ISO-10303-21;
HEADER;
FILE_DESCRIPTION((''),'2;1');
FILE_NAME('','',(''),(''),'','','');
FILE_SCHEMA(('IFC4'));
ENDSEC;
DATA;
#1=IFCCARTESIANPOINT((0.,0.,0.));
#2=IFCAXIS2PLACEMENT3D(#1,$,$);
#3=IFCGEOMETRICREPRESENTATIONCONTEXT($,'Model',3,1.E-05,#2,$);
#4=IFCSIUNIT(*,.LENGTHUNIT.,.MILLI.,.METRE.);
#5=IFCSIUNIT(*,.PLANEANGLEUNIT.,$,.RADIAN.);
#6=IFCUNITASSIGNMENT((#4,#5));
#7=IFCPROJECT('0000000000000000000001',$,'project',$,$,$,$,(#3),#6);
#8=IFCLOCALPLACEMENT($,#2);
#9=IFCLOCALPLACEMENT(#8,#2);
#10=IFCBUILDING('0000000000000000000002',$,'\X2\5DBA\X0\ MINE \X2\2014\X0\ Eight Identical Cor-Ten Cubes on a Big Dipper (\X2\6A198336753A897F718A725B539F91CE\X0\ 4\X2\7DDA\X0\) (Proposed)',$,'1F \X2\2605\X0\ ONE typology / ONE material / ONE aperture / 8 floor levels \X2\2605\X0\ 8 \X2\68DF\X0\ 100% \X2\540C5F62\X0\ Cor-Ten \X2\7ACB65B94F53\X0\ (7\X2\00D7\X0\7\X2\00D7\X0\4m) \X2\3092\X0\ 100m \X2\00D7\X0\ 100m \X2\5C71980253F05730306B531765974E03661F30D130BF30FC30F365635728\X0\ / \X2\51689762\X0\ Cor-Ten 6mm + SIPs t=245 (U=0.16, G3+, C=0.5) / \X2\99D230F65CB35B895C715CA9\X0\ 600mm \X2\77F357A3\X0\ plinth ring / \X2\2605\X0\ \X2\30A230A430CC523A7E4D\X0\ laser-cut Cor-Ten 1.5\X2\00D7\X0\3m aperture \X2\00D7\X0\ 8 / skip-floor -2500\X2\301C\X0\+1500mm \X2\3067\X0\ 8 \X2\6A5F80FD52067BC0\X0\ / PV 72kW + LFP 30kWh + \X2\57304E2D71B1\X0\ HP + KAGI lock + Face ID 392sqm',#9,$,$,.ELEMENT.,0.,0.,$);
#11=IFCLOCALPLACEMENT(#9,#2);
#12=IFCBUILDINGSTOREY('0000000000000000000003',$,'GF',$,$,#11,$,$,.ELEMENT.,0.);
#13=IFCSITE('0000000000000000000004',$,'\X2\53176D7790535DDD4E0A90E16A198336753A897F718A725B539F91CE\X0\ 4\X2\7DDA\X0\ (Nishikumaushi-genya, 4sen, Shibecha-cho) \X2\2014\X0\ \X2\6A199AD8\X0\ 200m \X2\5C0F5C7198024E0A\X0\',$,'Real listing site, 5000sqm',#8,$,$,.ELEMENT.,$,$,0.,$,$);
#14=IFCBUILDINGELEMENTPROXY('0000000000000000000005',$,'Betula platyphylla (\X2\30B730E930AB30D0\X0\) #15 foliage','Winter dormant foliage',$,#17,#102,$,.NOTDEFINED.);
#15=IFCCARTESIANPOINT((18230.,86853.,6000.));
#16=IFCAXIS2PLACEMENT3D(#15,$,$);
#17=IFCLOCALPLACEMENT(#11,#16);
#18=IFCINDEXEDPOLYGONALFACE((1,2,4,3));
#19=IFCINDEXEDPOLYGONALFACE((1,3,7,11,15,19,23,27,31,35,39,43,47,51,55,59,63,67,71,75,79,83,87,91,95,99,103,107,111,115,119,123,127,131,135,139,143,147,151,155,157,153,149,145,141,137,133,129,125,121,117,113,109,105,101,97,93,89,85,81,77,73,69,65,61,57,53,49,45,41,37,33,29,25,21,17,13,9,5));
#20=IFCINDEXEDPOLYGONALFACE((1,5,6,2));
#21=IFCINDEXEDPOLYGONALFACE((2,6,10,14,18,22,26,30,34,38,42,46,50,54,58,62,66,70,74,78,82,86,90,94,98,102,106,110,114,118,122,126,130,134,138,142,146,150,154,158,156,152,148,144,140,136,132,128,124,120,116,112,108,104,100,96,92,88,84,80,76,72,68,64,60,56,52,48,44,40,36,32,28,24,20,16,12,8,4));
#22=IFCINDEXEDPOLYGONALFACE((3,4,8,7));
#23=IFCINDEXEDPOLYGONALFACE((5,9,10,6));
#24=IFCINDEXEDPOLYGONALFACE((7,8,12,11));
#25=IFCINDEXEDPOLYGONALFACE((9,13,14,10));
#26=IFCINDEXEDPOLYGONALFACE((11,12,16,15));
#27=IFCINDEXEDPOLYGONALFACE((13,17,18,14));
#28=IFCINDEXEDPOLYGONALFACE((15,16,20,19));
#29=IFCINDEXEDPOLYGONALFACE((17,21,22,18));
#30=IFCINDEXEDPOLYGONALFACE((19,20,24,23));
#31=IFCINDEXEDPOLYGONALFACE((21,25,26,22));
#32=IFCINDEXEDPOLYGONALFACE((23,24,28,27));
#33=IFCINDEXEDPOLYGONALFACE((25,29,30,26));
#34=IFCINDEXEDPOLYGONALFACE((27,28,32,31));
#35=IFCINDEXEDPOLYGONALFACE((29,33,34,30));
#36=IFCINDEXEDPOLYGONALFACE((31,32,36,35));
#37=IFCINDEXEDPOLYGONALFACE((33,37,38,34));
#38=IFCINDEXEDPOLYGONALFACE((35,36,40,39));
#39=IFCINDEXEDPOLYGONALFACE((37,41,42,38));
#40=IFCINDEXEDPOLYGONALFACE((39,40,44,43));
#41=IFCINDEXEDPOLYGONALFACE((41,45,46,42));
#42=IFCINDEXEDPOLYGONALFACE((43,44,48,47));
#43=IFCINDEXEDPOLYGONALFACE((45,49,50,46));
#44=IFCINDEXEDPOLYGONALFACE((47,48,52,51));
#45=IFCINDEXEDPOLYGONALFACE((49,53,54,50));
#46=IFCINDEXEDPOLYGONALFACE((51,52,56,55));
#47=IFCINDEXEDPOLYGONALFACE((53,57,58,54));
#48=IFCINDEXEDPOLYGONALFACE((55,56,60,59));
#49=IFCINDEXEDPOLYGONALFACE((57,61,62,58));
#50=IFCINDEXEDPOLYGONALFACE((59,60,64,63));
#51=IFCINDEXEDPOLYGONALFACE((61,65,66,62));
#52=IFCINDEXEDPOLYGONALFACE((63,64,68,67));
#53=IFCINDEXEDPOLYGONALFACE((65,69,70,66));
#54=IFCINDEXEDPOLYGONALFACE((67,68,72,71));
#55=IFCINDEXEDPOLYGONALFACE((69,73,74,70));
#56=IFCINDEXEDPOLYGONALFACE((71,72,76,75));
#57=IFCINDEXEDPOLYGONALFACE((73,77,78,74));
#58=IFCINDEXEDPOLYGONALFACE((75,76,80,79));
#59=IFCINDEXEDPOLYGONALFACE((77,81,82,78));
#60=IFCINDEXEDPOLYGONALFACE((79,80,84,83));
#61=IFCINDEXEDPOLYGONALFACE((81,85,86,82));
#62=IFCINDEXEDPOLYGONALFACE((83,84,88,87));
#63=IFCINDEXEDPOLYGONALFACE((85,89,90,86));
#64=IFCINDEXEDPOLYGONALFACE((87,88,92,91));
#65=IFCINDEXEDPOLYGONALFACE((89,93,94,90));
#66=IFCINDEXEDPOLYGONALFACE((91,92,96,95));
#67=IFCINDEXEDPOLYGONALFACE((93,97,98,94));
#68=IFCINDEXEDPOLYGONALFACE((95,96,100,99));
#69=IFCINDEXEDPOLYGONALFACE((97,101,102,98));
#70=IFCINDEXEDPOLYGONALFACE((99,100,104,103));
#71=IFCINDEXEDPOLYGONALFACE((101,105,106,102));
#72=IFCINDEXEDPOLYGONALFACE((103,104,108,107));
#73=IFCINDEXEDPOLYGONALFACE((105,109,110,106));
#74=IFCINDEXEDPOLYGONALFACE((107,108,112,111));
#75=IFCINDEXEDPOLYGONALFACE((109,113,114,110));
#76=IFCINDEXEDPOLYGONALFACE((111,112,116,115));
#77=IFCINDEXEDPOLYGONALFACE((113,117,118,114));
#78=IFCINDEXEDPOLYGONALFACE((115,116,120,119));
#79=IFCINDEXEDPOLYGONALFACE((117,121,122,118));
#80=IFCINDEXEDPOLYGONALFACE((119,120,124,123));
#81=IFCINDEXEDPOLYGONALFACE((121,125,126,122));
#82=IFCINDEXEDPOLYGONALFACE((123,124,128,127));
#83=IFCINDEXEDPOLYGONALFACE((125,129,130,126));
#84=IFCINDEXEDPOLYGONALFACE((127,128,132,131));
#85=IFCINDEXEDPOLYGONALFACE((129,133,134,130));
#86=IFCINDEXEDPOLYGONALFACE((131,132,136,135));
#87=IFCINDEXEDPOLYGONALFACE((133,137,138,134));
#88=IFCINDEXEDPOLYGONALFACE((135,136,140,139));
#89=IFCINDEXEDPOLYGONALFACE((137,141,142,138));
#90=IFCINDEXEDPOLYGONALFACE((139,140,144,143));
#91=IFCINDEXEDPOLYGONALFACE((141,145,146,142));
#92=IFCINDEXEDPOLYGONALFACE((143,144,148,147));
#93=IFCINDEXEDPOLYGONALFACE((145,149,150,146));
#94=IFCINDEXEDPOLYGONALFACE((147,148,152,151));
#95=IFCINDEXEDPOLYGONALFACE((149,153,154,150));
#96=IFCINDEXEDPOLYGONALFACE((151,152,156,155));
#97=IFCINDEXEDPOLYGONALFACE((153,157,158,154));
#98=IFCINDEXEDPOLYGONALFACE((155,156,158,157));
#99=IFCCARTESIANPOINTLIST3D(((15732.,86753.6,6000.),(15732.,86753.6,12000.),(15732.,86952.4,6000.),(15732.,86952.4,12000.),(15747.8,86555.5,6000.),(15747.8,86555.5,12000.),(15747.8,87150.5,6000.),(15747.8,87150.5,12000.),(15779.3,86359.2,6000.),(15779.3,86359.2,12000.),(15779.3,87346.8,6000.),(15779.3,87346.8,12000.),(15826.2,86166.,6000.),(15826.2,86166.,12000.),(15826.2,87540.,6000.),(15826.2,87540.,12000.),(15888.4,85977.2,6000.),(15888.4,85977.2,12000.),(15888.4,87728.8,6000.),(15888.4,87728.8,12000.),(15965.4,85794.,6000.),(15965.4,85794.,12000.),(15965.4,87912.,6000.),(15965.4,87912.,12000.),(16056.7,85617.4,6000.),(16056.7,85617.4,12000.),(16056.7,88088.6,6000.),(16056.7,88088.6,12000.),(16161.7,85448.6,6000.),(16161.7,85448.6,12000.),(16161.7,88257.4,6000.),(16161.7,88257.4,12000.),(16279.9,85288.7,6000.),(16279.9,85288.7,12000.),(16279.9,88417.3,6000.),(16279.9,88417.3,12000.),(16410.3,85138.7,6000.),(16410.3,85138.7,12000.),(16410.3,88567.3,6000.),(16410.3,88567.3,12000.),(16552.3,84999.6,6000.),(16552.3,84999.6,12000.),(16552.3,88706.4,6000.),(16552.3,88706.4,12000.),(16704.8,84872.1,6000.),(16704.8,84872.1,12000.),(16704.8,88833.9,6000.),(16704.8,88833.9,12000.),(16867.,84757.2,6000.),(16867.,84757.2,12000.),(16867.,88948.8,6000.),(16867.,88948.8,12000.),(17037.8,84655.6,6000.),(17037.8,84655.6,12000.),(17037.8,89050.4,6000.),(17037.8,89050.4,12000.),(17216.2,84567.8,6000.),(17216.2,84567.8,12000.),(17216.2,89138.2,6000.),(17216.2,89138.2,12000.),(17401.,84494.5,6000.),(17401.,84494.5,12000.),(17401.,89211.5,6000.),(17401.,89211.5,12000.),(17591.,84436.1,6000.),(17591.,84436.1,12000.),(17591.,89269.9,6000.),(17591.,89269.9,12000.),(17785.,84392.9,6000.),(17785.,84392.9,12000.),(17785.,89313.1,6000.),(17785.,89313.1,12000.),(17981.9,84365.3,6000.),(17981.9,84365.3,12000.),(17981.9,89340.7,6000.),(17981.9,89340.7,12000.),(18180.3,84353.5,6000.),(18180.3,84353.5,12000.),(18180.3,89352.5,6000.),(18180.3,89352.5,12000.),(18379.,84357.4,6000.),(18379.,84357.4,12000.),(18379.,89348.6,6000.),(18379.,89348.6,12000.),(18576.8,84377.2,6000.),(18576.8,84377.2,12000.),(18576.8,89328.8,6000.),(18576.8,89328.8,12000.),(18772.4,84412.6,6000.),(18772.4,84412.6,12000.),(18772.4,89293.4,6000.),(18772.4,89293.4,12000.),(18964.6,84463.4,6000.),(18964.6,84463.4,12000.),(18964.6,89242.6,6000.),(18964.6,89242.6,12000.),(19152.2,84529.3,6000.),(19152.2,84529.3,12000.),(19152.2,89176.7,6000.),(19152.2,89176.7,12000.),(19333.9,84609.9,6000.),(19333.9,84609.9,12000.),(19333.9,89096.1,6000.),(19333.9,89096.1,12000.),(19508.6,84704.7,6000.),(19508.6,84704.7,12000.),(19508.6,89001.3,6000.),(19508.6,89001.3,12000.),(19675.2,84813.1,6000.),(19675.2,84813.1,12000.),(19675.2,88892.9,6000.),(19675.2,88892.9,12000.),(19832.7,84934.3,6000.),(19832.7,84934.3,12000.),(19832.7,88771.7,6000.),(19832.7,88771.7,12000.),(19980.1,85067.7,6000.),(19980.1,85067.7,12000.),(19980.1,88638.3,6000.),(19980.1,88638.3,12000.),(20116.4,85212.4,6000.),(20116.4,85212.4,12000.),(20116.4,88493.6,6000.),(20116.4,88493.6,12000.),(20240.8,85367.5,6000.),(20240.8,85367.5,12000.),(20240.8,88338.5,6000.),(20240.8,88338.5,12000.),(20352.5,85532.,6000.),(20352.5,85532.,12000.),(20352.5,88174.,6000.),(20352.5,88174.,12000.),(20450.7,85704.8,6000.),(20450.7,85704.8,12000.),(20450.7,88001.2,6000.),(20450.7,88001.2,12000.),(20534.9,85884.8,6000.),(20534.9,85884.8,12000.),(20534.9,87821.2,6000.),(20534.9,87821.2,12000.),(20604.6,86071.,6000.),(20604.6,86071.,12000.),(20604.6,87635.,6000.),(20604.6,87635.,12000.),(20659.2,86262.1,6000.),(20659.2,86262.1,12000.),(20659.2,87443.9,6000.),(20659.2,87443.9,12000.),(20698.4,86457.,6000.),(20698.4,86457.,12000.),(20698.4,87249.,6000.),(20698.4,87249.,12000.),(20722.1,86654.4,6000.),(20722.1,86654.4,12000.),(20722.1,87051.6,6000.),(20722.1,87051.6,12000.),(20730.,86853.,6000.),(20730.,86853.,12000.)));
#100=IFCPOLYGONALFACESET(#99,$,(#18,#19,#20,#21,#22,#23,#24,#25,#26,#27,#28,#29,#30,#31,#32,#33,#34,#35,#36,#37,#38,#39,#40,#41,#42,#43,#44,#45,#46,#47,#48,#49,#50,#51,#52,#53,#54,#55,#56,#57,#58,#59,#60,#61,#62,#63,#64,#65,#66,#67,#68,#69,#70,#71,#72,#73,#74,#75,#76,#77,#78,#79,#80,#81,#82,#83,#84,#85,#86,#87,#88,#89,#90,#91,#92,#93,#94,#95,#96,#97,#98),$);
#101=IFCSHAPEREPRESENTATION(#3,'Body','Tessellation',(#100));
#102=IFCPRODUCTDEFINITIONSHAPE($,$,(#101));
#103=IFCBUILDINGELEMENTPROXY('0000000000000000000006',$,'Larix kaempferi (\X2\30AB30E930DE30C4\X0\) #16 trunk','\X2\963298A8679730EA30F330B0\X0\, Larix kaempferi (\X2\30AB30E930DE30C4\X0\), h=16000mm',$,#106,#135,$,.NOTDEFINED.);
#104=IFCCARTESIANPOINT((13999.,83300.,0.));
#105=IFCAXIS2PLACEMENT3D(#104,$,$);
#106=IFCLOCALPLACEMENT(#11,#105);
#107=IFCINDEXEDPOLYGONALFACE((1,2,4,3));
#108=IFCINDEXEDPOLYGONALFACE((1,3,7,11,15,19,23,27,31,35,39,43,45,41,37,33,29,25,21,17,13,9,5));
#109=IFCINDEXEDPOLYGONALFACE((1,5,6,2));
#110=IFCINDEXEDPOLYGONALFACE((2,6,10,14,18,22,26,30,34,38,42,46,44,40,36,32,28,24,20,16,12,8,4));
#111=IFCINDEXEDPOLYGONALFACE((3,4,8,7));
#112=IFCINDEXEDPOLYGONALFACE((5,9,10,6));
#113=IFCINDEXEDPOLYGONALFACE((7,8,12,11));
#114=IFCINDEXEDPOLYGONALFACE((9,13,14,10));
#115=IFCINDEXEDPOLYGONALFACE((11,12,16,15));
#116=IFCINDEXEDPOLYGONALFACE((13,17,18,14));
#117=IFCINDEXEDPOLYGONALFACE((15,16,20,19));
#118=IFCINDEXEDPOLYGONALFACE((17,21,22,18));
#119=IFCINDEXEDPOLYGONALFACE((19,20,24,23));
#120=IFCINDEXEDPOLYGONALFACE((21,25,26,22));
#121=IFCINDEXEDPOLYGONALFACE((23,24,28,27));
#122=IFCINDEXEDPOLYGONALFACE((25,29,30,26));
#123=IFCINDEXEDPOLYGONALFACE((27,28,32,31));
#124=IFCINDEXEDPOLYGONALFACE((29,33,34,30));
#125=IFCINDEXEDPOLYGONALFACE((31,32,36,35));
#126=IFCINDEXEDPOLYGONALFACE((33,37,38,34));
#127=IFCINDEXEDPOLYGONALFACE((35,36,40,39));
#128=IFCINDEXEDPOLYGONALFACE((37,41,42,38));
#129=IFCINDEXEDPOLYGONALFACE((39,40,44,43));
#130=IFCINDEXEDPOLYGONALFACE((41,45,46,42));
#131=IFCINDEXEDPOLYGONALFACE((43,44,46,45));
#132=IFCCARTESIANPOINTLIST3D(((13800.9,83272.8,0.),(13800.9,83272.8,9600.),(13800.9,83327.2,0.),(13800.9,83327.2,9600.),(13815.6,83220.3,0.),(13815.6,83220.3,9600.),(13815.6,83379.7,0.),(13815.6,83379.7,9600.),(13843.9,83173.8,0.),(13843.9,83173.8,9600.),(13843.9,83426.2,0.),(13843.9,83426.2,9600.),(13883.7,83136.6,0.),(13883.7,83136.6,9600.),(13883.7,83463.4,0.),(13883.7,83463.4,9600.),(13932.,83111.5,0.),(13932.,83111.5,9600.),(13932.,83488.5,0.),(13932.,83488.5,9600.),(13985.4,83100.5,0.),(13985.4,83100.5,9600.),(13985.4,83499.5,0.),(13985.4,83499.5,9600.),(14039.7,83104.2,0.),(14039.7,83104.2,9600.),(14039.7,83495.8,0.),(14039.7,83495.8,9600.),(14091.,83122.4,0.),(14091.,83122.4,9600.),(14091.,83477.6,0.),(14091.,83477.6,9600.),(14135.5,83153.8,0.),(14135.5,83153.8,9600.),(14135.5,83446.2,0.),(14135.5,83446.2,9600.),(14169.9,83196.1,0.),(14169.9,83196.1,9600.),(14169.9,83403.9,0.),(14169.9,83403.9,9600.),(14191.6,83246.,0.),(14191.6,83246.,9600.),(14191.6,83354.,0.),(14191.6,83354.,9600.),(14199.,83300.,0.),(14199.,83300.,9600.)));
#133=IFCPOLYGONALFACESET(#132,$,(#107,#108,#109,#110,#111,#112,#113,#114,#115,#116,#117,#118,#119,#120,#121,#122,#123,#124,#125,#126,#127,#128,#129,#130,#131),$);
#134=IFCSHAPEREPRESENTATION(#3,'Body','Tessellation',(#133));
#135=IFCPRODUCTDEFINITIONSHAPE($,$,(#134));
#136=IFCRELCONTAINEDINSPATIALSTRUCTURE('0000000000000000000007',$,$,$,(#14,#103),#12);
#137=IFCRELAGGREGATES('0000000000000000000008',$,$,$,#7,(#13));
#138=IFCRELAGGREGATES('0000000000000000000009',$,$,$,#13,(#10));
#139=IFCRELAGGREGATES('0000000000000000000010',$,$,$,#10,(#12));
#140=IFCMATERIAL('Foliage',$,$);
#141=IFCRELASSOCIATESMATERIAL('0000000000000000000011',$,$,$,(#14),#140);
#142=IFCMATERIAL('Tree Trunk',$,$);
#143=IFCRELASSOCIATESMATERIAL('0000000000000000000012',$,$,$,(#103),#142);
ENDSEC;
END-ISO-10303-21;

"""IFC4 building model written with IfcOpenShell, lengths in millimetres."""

from ifc_helpers import new_model, si_unit, frame, origin, origin_2d, place, context, project, spatial, circle, extrude, material, element, save


model = new_model("IFC4")

# Units and contexts
model_context = context("Model", 3, precision=1e-05, world=origin())
ifc_project = project(units=[si_unit("LENGTHUNIT", "METRE", prefix="MILLI"), si_unit("PLANEANGLEUNIT", "RADIAN")], contexts=[model_context])

# Site, building, storey
site_placement = place(None, origin())
site = spatial("IfcSite", under=ifc_project, at=site_placement, Name="北海道川上郡標茶町西熊牛原野 4線 (Nishikumaushi-genya, 4sen, Shibecha-cho) — 標高 200m 小山頂上", ObjectType="Real listing site, 5000sqm", CompositionType="ELEMENT", RefElevation=0.0)
building_placement = place(site_placement, origin())
building = spatial("IfcBuilding", under=site, at=building_placement, Name="嶺 MINE — Eight Identical Cor-Ten Cubes on a Big Dipper (標茶町西熊牛原野 4線) (Proposed)", ObjectType="1F ★ ONE typology / ONE material / ONE aperture / 8 floor levels ★ 8 棟 100% 同形 Cor-Ten 立方体 (7×7×4m) を 100m × 100m 山頂台地に北斗七星パターン散在 / 全面 Cor-Ten 6mm + SIPs t=245 (U=0.16, G3+, C=0.5) / 駒ヶ岳安山岩 600mm 石垣 plinth ring / ★ アイヌ刺繍 laser-cut Cor-Ten 1.5×3m aperture × 8 / skip-floor -2500〜+1500mm で 8 機能分節 / PV 72kW + LFP 30kWh + 地中熱 HP + KAGI lock + Face ID 392sqm", CompositionType="ELEMENT", ElevationOfRefHeight=0.0, ElevationOfTerrain=0.0)
storey_placement = place(building_placement, origin())
storey = spatial("IfcBuildingStorey", under=building, at=storey_placement, Name="GF", CompositionType="ELEMENT", Elevation=0.0)

# Building element proxies
ifc_material_1 = material(Name="Tree Trunk")
ifc_material_2 = material(Name="Foliage")
proxy_1_placement = place(storey_placement, frame((18230.0, 86853.0, 6000.0)))
element("IfcBuildingElementProxy", 1, at=proxy_1_placement, inside=storey, material=ifc_material_2, Name="Betula platyphylla (シラカバ) #15 foliage", Description="Winter dormant foliage", PredefinedType="NOTDEFINED", context=model_context, shape_type="SweptSolid", body=[
    extrude(circle(Radius=2500.0, at=origin_2d()), frame((18230.0, 86853.0, 6000.0)), (0.0, 0.0, 1.0), 6000.0),
])
proxy_2_placement = place(storey_placement, frame((13999.0, 83300.0, 0.0)))
element("IfcBuildingElementProxy", 2, at=proxy_2_placement, inside=storey, material=ifc_material_1, Name="Larix kaempferi (カラマツ) #16 trunk", Description="防風林リング, Larix kaempferi (カラマツ), h=16000mm", PredefinedType="NOTDEFINED", context=model_context, shape_type="SweptSolid", body=[
    extrude(circle(Radius=200.0, at=origin_2d()), frame((13999.0, 83300.0, 0.0)), (0.0, 0.0, 1.0), 9600.0),
])

save(model, "model.ifc")
